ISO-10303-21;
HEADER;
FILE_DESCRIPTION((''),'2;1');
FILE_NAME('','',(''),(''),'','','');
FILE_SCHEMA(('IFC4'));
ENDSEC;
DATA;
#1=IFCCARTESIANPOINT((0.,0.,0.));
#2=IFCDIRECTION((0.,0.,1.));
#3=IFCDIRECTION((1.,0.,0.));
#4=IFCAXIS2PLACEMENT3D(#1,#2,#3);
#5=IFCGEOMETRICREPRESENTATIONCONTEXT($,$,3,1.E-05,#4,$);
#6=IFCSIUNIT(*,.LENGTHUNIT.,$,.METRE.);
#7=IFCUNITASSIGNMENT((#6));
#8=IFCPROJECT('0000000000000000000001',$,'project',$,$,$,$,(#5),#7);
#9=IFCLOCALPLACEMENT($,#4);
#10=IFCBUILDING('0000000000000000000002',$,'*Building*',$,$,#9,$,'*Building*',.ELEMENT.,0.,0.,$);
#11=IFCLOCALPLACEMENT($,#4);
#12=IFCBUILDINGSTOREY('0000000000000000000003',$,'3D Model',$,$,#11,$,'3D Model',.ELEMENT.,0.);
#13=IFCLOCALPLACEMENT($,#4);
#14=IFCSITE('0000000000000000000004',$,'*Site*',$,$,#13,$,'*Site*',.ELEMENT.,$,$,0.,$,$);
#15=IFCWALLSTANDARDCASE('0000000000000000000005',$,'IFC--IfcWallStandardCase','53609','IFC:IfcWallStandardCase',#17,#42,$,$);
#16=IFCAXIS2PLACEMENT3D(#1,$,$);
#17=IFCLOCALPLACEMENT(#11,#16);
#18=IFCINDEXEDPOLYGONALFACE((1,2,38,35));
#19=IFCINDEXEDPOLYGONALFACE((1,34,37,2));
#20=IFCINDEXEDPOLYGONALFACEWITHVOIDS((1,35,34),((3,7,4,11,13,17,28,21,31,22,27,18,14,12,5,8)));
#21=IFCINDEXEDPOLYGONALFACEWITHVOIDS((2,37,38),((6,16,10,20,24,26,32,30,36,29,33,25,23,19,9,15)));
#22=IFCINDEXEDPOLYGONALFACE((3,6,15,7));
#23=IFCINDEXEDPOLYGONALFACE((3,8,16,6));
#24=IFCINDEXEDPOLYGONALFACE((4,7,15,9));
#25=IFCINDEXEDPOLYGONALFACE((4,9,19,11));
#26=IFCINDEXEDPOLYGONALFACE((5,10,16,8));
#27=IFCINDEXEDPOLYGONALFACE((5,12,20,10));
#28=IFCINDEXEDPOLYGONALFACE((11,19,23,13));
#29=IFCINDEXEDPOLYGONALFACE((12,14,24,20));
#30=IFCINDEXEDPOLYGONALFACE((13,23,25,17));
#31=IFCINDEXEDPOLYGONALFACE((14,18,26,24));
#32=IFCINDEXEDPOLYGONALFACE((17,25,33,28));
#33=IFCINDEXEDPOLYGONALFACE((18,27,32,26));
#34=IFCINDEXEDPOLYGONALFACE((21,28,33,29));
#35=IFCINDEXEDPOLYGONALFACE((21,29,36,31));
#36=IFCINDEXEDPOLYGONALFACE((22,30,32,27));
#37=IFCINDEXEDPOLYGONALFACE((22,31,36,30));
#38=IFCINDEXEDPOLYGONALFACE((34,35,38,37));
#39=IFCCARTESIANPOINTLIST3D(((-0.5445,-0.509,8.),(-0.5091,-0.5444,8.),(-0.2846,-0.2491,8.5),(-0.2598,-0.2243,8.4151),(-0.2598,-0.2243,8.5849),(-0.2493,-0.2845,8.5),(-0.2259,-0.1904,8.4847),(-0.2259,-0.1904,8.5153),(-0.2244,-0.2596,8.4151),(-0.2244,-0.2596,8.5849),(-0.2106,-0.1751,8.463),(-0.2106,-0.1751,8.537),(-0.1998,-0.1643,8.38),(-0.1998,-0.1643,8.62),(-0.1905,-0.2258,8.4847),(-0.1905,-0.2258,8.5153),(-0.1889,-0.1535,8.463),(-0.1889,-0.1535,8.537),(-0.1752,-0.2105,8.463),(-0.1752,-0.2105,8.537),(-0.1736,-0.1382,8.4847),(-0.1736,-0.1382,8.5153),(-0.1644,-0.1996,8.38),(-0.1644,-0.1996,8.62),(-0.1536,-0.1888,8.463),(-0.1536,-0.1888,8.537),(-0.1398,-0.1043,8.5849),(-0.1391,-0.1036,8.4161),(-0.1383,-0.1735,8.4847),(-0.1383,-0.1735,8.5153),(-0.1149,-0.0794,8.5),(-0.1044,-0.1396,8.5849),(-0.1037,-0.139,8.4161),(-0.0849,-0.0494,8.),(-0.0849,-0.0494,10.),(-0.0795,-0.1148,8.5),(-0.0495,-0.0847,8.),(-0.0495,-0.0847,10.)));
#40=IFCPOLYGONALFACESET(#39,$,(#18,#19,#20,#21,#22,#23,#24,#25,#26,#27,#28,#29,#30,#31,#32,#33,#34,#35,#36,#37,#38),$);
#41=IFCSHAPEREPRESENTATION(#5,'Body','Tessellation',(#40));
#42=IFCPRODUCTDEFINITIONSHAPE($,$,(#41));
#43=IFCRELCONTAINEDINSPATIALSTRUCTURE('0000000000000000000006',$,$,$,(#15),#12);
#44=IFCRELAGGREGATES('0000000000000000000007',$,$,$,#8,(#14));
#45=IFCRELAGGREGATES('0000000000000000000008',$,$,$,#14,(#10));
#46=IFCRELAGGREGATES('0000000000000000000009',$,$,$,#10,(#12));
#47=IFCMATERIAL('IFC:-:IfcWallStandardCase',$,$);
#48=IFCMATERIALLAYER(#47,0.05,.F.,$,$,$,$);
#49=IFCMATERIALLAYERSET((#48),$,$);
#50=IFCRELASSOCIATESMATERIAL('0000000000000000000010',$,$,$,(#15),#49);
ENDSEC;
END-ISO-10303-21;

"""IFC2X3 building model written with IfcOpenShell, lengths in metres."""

from ifc_helpers import new_model, si_unit, frame, frame_2d, origin_with_axes, place, context, project, spatial, polyline, rectangle, outline, extrude, clip, halfspace, material, layer, layer_set, layer_usage, element, save


model = new_model("IFC2X3")

# Units and contexts
context_of_model = context(None, 3, precision=1e-05, world=origin_with_axes())
ifc_project = project(units=[si_unit("LENGTHUNIT", "METRE")], contexts=[context_of_model])

# Site, building, storey
site_placement = place(None, origin_with_axes())
site = spatial("IfcSite", under=ifc_project, at=site_placement, Name="*Site*", LongName="*Site*", CompositionType="ELEMENT", RefElevation=0.0)
building_placement = place(None, origin_with_axes())
building = spatial("IfcBuilding", under=site, at=building_placement, Name="*Building*", LongName="*Building*", CompositionType="ELEMENT", ElevationOfRefHeight=0.0, ElevationOfTerrain=0.0)
storey_placement = place(None, origin_with_axes())
storey = spatial("IfcBuildingStorey", under=building, at=storey_placement, Name="3D Model", LongName="3D Model", CompositionType="ELEMENT", Elevation=0.0)

# Wall, opening
ifc_material = material(Name="IFC:-:IfcWallStandardCase")
ifc_layer = layer(ifc_material, 0.05, ventilated=False)
ifc_layer_set = layer_set([ifc_layer])
ifc_layer_usage = layer_usage(ifc_layer_set, "AXIS2", "POSITIVE", 0.0)
wall_1_placement = place(None, frame((-0.0672, -0.0671, 8.0), z_axis=(0.0, 0.0, 1.0), x_axis=(-0.707105, -0.707109, 0.0)))
wall_1 = element("IfcWallStandardCase", 1, at=wall_1_placement, inside=storey, material=ifc_layer_usage, Name="IFC--IfcWallStandardCase", Description="53609", ObjectType="IFC:IfcWallStandardCase", context=context_of_model, shape_type="Clipping", body=[
    clip(extrude(rectangle(XDim=0.65, YDim=0.05, at=frame_2d((0.325, 0.0), x_axis=(1.0, 0.0))), origin_with_axes(), (0.0, 0.0, 1.0), 2.0), halfspace(frame((0.5879, 0.0, 0.1911), z_axis=(-0.951034, 0.000003, -0.309086), x_axis=(-0.000003, -1.0, 0.0)), True)),
])
opening_1_placement = place(wall_1_placement, frame((0.0425, 0.025, 0.38), z_axis=(0.0, 0.0, 1.0), x_axis=(1.0, 0.0, 0.0)))
element("IfcOpeningElement", 2, at=opening_1_placement, cuts=wall_1, context=context_of_model, shape_type="SweptSolid", body=[
    extrude(outline(polyline([(-0.157, 0.1047), (-0.2049, 0.0351), (-0.1353, 0.083), (-0.12, 0.0), (-0.1047, 0.083), (-0.0342, 0.0361), (-0.083, 0.1047), (0.0, 0.12), (-0.083, 0.1353), (-0.0351, 0.2049), (-0.1047, 0.157), (-0.12, 0.24), (-0.1353, 0.157), (-0.2049, 0.2049), (-0.157, 0.1353), (-0.24, 0.12), (-0.157, 0.1047)])), frame((0.0, 0.0, 0.0), z_axis=(0.0, 1.0, 0.0), x_axis=(-1.0, 0.0, 0.0)), (0.0, 0.0, -1.0), 0.15),
])

save(model, "model.ifc")
